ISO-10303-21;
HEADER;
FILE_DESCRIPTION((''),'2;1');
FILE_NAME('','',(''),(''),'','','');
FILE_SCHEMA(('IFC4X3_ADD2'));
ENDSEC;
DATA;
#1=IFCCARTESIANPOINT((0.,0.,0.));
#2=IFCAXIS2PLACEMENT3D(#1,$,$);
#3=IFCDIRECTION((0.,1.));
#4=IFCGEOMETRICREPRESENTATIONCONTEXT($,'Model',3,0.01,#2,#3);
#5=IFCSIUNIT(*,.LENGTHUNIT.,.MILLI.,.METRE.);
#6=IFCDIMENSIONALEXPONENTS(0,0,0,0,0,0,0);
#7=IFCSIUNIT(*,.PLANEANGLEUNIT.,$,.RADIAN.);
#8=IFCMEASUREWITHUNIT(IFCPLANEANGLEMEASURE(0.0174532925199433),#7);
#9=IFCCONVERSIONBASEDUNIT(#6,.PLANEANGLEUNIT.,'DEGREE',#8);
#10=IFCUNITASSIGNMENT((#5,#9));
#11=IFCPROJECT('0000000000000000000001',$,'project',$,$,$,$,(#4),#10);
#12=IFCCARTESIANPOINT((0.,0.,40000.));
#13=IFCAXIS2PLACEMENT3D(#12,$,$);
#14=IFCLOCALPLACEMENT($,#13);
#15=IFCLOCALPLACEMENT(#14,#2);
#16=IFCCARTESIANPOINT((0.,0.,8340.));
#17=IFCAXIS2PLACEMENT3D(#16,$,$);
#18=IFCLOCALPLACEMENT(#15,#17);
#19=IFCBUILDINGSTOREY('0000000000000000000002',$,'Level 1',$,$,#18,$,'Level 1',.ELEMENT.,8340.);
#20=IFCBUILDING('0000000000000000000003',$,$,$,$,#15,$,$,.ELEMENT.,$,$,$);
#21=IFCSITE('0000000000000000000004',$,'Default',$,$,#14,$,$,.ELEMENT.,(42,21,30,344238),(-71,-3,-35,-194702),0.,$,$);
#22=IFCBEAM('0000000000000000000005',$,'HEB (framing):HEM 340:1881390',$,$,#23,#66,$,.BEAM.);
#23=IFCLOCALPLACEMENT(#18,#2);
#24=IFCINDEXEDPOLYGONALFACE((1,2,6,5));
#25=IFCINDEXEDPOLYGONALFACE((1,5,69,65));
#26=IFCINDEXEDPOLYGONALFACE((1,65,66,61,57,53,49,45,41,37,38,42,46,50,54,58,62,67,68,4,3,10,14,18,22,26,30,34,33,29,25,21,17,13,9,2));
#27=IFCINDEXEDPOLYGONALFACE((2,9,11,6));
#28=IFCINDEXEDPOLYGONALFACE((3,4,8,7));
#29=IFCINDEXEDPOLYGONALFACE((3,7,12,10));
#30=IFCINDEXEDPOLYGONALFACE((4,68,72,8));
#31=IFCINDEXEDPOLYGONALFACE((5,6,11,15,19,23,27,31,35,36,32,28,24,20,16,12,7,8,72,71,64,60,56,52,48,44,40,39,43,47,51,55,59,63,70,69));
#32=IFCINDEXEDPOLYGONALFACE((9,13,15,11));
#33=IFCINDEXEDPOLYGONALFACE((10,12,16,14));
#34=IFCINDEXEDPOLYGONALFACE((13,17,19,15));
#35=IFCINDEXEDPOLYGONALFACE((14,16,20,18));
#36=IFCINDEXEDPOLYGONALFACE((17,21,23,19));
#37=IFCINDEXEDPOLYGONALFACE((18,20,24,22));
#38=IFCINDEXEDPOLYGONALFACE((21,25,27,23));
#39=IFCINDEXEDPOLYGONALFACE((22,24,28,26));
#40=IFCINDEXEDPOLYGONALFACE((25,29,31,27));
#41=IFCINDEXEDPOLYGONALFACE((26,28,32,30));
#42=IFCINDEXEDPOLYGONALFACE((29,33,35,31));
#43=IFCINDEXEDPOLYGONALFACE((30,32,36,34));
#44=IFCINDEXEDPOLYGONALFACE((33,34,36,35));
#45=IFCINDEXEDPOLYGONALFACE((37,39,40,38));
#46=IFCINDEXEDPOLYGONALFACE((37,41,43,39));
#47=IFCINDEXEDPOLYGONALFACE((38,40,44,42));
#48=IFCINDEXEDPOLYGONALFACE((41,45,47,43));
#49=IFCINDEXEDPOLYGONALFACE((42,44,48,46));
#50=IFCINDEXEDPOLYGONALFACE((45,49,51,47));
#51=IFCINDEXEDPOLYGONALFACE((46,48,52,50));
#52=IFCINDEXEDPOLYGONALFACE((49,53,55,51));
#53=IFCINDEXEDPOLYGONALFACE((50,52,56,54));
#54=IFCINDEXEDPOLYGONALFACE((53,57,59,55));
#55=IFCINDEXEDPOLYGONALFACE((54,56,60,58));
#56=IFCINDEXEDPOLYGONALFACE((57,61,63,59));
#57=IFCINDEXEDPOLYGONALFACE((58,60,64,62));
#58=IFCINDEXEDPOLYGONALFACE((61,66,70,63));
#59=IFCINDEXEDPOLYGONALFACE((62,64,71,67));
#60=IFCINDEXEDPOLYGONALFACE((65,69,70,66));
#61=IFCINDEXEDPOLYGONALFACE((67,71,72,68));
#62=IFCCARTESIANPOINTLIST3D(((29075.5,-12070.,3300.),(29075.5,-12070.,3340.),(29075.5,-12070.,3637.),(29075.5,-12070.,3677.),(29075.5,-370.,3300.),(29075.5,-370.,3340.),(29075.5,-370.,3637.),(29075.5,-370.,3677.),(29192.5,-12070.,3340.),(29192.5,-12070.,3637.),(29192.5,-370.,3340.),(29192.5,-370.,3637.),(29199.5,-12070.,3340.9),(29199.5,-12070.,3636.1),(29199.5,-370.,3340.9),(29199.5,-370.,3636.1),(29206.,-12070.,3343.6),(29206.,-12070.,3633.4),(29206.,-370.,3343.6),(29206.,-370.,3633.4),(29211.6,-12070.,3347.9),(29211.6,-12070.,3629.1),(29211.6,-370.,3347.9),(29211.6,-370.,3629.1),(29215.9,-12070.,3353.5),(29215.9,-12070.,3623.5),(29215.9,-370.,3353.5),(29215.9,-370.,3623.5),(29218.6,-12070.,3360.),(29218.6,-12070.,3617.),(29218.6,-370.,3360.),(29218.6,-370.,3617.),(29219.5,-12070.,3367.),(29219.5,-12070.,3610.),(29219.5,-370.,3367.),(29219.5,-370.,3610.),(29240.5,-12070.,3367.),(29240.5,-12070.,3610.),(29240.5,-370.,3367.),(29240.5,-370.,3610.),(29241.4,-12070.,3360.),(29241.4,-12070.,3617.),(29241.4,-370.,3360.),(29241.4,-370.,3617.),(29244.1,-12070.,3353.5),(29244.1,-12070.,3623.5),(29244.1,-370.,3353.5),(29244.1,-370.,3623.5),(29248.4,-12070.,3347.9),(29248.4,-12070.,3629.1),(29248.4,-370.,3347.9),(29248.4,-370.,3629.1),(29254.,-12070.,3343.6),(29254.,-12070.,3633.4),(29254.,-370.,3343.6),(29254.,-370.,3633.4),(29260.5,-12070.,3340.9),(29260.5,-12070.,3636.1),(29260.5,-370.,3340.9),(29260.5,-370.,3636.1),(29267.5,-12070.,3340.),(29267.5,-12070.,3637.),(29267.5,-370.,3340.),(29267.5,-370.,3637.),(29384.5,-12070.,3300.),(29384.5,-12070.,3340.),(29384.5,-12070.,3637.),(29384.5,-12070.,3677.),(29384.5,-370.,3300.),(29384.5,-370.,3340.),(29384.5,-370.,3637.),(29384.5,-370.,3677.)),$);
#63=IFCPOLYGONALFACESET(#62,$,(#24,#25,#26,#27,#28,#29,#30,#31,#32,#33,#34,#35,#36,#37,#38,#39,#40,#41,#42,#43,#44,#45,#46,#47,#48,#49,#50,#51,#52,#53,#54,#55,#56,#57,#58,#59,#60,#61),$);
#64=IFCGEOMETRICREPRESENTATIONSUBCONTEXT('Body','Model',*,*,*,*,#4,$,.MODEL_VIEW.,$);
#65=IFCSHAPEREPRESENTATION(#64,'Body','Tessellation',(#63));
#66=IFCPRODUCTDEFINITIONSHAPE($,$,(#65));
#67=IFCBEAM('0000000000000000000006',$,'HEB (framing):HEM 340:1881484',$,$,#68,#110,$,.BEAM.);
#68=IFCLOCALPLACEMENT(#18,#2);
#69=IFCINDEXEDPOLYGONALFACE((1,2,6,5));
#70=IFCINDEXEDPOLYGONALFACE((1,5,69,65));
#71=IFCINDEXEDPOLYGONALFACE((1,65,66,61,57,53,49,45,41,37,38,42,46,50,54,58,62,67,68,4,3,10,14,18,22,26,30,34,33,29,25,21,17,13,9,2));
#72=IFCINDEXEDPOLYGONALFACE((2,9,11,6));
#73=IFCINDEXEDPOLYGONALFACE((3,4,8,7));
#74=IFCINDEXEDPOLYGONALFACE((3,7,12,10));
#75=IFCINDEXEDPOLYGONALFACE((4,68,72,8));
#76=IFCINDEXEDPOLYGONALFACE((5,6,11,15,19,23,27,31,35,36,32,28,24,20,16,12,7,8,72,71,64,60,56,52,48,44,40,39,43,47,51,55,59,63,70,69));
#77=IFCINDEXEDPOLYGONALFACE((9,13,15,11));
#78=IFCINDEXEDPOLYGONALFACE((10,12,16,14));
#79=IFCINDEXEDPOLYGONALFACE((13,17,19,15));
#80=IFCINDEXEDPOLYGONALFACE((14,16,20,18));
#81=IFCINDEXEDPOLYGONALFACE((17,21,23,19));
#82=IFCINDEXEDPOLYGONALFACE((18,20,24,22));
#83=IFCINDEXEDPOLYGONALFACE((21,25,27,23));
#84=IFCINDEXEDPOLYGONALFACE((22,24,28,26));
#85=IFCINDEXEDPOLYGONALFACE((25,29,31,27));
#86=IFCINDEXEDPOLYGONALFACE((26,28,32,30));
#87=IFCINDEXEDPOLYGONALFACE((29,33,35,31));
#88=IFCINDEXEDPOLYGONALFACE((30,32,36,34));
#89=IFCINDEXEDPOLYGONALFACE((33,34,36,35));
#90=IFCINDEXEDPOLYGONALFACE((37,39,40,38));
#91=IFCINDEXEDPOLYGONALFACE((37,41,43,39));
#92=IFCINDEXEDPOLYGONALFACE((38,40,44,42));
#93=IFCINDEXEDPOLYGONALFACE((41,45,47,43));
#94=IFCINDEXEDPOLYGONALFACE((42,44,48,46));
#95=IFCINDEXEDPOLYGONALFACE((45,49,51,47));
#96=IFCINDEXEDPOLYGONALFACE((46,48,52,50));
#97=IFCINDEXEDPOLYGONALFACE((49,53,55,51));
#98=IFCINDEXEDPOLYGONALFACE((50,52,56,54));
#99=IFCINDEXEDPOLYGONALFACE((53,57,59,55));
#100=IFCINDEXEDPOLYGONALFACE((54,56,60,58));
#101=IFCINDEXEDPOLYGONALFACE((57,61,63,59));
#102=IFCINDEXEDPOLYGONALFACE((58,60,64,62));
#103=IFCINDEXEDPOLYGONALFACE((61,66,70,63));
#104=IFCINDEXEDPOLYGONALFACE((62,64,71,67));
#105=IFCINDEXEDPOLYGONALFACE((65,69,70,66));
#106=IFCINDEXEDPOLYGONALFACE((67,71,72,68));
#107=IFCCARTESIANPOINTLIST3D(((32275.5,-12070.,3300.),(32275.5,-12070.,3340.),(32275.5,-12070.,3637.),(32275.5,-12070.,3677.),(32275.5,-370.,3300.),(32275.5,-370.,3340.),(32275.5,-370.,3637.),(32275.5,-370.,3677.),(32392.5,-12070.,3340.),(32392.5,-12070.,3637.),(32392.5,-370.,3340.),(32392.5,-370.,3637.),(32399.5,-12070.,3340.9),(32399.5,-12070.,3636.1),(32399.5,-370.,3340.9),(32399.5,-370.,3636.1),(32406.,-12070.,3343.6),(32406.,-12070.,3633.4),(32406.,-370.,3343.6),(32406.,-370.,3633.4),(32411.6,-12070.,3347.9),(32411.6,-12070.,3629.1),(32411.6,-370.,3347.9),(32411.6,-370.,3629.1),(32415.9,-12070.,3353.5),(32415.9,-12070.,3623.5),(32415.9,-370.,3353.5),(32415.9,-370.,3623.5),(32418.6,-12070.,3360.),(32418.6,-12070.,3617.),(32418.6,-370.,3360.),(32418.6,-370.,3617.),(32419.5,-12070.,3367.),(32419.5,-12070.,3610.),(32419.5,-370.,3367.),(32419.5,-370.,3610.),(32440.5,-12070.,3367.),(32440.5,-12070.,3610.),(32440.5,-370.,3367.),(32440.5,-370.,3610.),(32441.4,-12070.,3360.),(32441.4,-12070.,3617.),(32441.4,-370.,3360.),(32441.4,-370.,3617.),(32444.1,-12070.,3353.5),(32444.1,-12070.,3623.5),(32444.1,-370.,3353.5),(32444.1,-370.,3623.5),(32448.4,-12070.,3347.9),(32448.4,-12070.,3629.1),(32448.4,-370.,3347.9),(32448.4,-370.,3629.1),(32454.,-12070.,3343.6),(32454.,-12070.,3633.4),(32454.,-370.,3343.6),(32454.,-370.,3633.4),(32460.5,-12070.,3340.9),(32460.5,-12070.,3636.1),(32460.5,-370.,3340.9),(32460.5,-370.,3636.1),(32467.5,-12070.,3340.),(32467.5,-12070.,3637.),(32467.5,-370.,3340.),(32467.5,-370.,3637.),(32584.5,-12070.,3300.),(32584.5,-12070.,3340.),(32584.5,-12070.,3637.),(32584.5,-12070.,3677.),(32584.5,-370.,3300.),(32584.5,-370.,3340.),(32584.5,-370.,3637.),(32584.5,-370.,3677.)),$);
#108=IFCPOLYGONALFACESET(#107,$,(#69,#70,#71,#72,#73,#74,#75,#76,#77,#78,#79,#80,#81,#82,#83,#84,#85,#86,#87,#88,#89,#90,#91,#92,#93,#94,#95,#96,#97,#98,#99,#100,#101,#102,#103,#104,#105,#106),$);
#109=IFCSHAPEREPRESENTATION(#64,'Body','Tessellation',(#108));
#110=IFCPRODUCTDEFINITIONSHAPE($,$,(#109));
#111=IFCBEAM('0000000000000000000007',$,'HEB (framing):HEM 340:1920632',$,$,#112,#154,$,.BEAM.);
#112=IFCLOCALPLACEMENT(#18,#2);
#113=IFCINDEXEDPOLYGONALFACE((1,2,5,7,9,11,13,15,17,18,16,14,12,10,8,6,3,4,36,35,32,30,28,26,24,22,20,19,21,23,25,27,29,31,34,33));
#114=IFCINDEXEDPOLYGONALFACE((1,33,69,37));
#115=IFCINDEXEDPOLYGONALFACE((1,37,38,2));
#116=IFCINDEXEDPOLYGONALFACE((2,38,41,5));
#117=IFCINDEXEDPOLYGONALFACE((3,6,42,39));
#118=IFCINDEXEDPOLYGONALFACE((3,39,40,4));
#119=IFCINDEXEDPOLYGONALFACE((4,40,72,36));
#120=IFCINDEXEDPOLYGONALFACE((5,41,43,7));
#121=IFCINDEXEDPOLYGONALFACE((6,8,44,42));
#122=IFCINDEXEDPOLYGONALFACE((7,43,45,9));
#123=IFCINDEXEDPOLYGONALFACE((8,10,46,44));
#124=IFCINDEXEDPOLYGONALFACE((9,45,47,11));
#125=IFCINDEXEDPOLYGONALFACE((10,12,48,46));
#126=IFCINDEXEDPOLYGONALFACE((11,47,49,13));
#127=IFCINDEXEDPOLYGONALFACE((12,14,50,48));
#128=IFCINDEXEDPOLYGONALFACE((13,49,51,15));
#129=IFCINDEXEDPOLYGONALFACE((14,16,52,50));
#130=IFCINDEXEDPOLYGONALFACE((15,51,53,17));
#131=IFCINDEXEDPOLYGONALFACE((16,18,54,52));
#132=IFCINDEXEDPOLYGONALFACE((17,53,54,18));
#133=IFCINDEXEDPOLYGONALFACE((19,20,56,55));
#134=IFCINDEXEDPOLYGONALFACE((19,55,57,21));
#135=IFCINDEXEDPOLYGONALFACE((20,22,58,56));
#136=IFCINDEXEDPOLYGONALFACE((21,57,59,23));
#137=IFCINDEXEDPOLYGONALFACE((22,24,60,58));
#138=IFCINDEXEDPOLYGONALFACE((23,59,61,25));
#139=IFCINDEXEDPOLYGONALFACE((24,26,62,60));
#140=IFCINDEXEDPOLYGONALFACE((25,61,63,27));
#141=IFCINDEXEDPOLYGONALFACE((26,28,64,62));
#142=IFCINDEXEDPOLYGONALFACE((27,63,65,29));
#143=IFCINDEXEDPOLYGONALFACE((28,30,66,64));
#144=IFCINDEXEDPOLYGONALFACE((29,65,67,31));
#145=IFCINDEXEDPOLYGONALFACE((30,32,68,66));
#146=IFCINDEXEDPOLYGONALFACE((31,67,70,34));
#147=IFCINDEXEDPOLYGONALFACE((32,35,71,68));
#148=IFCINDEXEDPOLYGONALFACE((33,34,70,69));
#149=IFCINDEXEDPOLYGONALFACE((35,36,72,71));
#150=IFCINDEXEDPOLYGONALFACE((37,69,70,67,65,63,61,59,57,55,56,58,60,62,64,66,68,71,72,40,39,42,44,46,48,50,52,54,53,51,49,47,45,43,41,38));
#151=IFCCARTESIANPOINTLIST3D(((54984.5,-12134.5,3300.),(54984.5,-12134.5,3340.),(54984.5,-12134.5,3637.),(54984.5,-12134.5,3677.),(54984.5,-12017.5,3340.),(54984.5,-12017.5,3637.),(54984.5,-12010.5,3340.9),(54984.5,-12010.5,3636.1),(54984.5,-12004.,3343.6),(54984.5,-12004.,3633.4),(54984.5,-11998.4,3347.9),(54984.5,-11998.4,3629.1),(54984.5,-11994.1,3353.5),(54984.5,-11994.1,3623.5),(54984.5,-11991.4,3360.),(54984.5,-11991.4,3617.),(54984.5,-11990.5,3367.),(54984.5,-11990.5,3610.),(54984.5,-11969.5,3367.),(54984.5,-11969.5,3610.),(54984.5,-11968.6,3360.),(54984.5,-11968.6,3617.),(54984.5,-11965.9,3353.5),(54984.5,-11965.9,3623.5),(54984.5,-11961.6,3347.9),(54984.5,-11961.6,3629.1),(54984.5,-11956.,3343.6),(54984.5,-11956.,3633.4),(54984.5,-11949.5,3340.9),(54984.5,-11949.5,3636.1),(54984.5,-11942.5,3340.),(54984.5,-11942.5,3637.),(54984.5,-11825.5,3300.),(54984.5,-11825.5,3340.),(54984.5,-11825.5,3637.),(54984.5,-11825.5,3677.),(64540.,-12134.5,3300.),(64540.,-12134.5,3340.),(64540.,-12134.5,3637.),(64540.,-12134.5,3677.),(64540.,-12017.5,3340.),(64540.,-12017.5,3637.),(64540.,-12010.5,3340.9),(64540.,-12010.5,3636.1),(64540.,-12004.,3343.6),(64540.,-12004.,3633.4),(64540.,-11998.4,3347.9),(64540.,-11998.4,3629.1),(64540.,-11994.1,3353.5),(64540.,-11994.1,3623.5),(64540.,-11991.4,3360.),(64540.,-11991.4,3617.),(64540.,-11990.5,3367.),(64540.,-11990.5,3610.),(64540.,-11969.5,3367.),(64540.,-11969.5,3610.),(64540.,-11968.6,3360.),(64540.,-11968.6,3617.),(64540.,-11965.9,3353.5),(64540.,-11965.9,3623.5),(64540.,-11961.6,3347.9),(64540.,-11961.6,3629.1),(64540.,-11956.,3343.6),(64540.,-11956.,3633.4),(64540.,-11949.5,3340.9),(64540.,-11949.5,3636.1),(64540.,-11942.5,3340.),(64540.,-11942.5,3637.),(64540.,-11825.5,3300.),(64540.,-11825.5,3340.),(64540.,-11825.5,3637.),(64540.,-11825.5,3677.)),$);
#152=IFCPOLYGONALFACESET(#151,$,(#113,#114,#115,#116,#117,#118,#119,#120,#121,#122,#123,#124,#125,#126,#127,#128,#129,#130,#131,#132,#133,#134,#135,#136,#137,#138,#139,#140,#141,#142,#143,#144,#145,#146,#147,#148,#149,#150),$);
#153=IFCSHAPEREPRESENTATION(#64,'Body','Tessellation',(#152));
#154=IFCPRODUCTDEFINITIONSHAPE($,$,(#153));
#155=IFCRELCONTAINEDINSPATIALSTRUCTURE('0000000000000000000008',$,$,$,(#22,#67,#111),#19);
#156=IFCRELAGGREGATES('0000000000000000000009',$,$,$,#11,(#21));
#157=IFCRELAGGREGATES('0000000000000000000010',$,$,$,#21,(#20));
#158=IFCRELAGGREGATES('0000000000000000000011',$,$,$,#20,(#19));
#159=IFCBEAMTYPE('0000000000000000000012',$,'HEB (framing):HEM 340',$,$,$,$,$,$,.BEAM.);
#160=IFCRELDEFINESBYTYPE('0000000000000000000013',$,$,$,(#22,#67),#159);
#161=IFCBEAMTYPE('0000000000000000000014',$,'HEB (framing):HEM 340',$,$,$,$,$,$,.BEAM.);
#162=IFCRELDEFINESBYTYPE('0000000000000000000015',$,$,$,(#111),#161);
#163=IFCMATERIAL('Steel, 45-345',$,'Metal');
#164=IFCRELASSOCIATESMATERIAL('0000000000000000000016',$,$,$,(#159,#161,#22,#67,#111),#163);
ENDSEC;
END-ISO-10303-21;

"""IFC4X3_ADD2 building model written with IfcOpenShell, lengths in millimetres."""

from ifc_helpers import new_model, entity, si_unit, converted_unit, direction, frame, frame_2d, origin, place, context, subcontext, project, spatial, polyline, circle_curve, parameter, trimmed, segment, composite_curve, outline, extrude, source, transform, mapped, material, material_profile, profile_set, profile_usage, type_object, type_shapes, element, save


model = new_model("IFC4X3_ADD2")

# Units and contexts
model_context = context("Model", 3, precision=0.01, world=origin(), true_north=direction((0.0, 1.0)))
body_context = subcontext(model_context, "Body", "Model", "MODEL_VIEW")
ifc_project = project(units=[si_unit("LENGTHUNIT", "METRE", prefix="MILLI"), converted_unit("PLANEANGLEUNIT", "DEGREE", entity("IfcPlaneAngleMeasure", 0.0174532925199433), si_unit("PLANEANGLEUNIT", "RADIAN"), dimensions=[0, 0, 0, 0, 0, 0, 0])], contexts=[model_context])

# Site, building, storey
site_placement = place(None, frame((0.0, 0.0, 40000.0)))
site = spatial("IfcSite", under=ifc_project, at=site_placement, Name="Default", CompositionType="ELEMENT", RefLatitude=(42, 21, 30, 344238), RefLongitude=(-71, -3, -35, -194702), RefElevation=0.0)
building_placement = place(site_placement, origin())
building = spatial("IfcBuilding", under=site, at=building_placement, CompositionType="ELEMENT")
storey_placement = place(building_placement, frame((0.0, 0.0, 8340.0)))
storey = spatial("IfcBuildingStorey", under=building, at=storey_placement, Name="Level 1", LongName="Level 1", CompositionType="ELEMENT", Elevation=8340.0)

# Shared definitions
ifc_material = material(Name="Steel, 45-345", Category="Metal")

# Beams
ifc_material_profile_1 = material_profile(ifc_material, outline(composite_curve([segment(polyline([(-154.5, -148.5), (-154.5, -188.5)]), True, "CONTINUOUS"), segment(polyline([(-154.5, -188.5), (154.5, -188.5)]), True, "CONTINUOUS"), segment(polyline([(154.5, -188.5), (154.5, -148.5)]), True, "CONTINUOUS"), segment(polyline([(154.5, -148.5), (37.5, -148.5)]), True, "CONTINUOUS"), segment(trimmed(circle_curve(frame_2d((37.5, -121.5), x_axis=(1.0, 0.0)), 27.0), [parameter(180.0)], [parameter(270.0)], True, "PARAMETER"), False, "CONTINUOUS"), segment(polyline([(10.5, -121.5), (10.5, 121.5)]), True, "CONTINUOUS"), segment(trimmed(circle_curve(frame_2d((37.5, 121.5), x_axis=(1.0, 0.0)), 27.0), [parameter(90.0)], [parameter(180.0)], True, "PARAMETER"), False, "CONTINUOUS"), segment(polyline([(37.5, 148.5), (154.5, 148.5)]), True, "CONTINUOUS"), segment(polyline([(154.5, 148.5), (154.5, 188.5)]), True, "CONTINUOUS"), segment(polyline([(154.5, 188.5), (-154.5, 188.5)]), True, "CONTINUOUS"), segment(polyline([(-154.5, 188.5), (-154.5, 148.5)]), True, "CONTINUOUS"), segment(polyline([(-154.5, 148.5), (-37.5, 148.5)]), True, "CONTINUOUS"), segment(trimmed(circle_curve(frame_2d((-37.5, 121.5), x_axis=(1.0, 0.0)), 27.0), [parameter(360.0)], [parameter(90.0)], True, "PARAMETER"), False, "CONTINUOUS"), segment(polyline([(-10.5, 121.5), (-10.5, -121.5)]), True, "CONTINUOUS"), segment(trimmed(circle_curve(frame_2d((-37.5, -121.5), x_axis=(1.0, 0.0)), 27.0), [parameter(270.0)], [parameter(0.0)], True, "PARAMETER"), False, "CONTINUOUS"), segment(polyline([(-37.5, -148.5), (-154.5, -148.5)]), True, "CONTINUOUS")], self_intersect=False)), Name="HEM 340")
ifc_profile_set_1 = profile_set([ifc_material_profile_1], Name="HEM 340")
ifc_profile_usage_1 = profile_usage(ifc_profile_set_1, cardinal=8)
beam_type_1 = type_object("IfcBeamType", Name="HEB (framing):HEM 340", PredefinedType="BEAM", material=ifc_profile_set_1)
shared_shape_1 = source(origin(), body_context, "Body", "SweptSolid", [
    extrude(outline(composite_curve([segment(polyline([(-154.5, -148.5), (-154.5, -188.5)]), True, "CONTINUOUS"), segment(polyline([(-154.5, -188.5), (154.5, -188.5)]), True, "CONTINUOUS"), segment(polyline([(154.5, -188.5), (154.5, -148.5)]), True, "CONTINUOUS"), segment(polyline([(154.5, -148.5), (37.5, -148.5)]), True, "CONTINUOUS"), segment(trimmed(circle_curve(frame_2d((37.5, -121.5), x_axis=(1.0, 0.0)), 27.0), [parameter(180.0)], [parameter(270.0)], True, "PARAMETER"), False, "CONTINUOUS"), segment(polyline([(10.5, -121.5), (10.5, 121.5)]), True, "CONTINUOUS"), segment(trimmed(circle_curve(frame_2d((37.5, 121.5), x_axis=(1.0, 0.0)), 27.0), [parameter(90.0)], [parameter(180.0)], True, "PARAMETER"), False, "CONTINUOUS"), segment(polyline([(37.5, 148.5), (154.5, 148.5)]), True, "CONTINUOUS"), segment(polyline([(154.5, 148.5), (154.5, 188.5)]), True, "CONTINUOUS"), segment(polyline([(154.5, 188.5), (-154.5, 188.5)]), True, "CONTINUOUS"), segment(polyline([(-154.5, 188.5), (-154.5, 148.5)]), True, "CONTINUOUS"), segment(polyline([(-154.5, 148.5), (-37.5, 148.5)]), True, "CONTINUOUS"), segment(trimmed(circle_curve(frame_2d((-37.5, 121.5), x_axis=(1.0, 0.0)), 27.0), [parameter(360.0)], [parameter(90.0)], True, "PARAMETER"), False, "CONTINUOUS"), segment(polyline([(-10.5, 121.5), (-10.5, -121.5)]), True, "CONTINUOUS"), segment(trimmed(circle_curve(frame_2d((-37.5, -121.5), x_axis=(1.0, 0.0)), 27.0), [parameter(270.0)], [parameter(0.0)], True, "PARAMETER"), False, "CONTINUOUS"), segment(polyline([(-37.5, -148.5), (-154.5, -148.5)]), True, "CONTINUOUS")], self_intersect=False)), frame((-5850.0, 0.0, 0.0), z_axis=(-1.0, 0.0, 0.0), x_axis=(0.0, -1.0, 0.0)), (0.0, 0.0, -1.0), 11700.0),
])
type_shapes(beam_type_1, [shared_shape_1])
for number, where, z_axis, x_axis, name in (
    (1, (29230.0, -6220.0, 3488.5), (0.0, 0.0, 1.0), (0.0, -1.0, 0.0), "HEB (framing):HEM 340:1881390"),
    (2, (32430.0, -6220.0, 3488.5), (0.0, 0.0, 1.0), (0.0, -1.0, 0.0), "HEB (framing):HEM 340:1881484"),
):
    element("IfcBeam", number, at=place(storey_placement, frame(where, z_axis=z_axis, x_axis=x_axis)), inside=storey, type_object=beam_type_1, material=ifc_profile_usage_1, Name=name, PredefinedType="BEAM", context=body_context, shape_type="MappedRepresentation", body=[
        mapped(shared_shape_1, transform((0.0, 0.0, 0.0), scale=1.0)),
    ])
beam_type_2 = type_object("IfcBeamType", Name="HEB (framing):HEM 340", PredefinedType="BEAM", material=ifc_profile_set_1)
shared_shape_2 = source(origin(), body_context, "Body", "SweptSolid", [
    extrude(outline(composite_curve([segment(polyline([(-154.5, -148.5), (-154.5, -188.5)]), True, "CONTINUOUS"), segment(polyline([(-154.5, -188.5), (154.5, -188.5)]), True, "CONTINUOUS"), segment(polyline([(154.5, -188.5), (154.5, -148.5)]), True, "CONTINUOUS"), segment(polyline([(154.5, -148.5), (37.5, -148.5)]), True, "CONTINUOUS"), segment(trimmed(circle_curve(frame_2d((37.5, -121.5), x_axis=(1.0, 0.0)), 27.0), [parameter(180.0)], [parameter(270.0)], True, "PARAMETER"), False, "CONTINUOUS"), segment(polyline([(10.5, -121.5), (10.5, 121.5)]), True, "CONTINUOUS"), segment(trimmed(circle_curve(frame_2d((37.5, 121.5), x_axis=(1.0, 0.0)), 27.0), [parameter(90.0)], [parameter(180.0)], True, "PARAMETER"), False, "CONTINUOUS"), segment(polyline([(37.5, 148.5), (154.5, 148.5)]), True, "CONTINUOUS"), segment(polyline([(154.5, 148.5), (154.5, 188.5)]), True, "CONTINUOUS"), segment(polyline([(154.5, 188.5), (-154.5, 188.5)]), True, "CONTINUOUS"), segment(polyline([(-154.5, 188.5), (-154.5, 148.5)]), True, "CONTINUOUS"), segment(polyline([(-154.5, 148.5), (-37.5, 148.5)]), True, "CONTINUOUS"), segment(trimmed(circle_curve(frame_2d((-37.5, 121.5), x_axis=(1.0, 0.0)), 27.0), [parameter(360.0)], [parameter(90.0)], True, "PARAMETER"), False, "CONTINUOUS"), segment(polyline([(-10.5, 121.5), (-10.5, -121.5)]), True, "CONTINUOUS"), segment(trimmed(circle_curve(frame_2d((-37.5, -121.5), x_axis=(1.0, 0.0)), 27.0), [parameter(270.0)], [parameter(0.0)], True, "PARAMETER"), False, "CONTINUOUS"), segment(polyline([(-37.5, -148.5), (-154.5, -148.5)]), True, "CONTINUOUS")], self_intersect=False)), frame((-4703.0, 0.0, 0.0), z_axis=(-1.0, 0.0, 0.0), x_axis=(0.0, -1.0, 0.0)), (0.0, 0.0, -1.0), 9555.5),
])
type_shapes(beam_type_2, [shared_shape_2])
beam_1_placement = place(storey_placement, frame((59687.5, -11980.0, 3488.5)))
element("IfcBeam", 3, at=beam_1_placement, inside=storey, type_object=beam_type_2, material=ifc_profile_usage_1, Name="HEB (framing):HEM 340:1920632", PredefinedType="BEAM", context=body_context, shape_type="MappedRepresentation", body=[
    mapped(shared_shape_2, transform((0.0, 0.0, 0.0), scale=1.0)),
])

save(model, "model.ifc")
